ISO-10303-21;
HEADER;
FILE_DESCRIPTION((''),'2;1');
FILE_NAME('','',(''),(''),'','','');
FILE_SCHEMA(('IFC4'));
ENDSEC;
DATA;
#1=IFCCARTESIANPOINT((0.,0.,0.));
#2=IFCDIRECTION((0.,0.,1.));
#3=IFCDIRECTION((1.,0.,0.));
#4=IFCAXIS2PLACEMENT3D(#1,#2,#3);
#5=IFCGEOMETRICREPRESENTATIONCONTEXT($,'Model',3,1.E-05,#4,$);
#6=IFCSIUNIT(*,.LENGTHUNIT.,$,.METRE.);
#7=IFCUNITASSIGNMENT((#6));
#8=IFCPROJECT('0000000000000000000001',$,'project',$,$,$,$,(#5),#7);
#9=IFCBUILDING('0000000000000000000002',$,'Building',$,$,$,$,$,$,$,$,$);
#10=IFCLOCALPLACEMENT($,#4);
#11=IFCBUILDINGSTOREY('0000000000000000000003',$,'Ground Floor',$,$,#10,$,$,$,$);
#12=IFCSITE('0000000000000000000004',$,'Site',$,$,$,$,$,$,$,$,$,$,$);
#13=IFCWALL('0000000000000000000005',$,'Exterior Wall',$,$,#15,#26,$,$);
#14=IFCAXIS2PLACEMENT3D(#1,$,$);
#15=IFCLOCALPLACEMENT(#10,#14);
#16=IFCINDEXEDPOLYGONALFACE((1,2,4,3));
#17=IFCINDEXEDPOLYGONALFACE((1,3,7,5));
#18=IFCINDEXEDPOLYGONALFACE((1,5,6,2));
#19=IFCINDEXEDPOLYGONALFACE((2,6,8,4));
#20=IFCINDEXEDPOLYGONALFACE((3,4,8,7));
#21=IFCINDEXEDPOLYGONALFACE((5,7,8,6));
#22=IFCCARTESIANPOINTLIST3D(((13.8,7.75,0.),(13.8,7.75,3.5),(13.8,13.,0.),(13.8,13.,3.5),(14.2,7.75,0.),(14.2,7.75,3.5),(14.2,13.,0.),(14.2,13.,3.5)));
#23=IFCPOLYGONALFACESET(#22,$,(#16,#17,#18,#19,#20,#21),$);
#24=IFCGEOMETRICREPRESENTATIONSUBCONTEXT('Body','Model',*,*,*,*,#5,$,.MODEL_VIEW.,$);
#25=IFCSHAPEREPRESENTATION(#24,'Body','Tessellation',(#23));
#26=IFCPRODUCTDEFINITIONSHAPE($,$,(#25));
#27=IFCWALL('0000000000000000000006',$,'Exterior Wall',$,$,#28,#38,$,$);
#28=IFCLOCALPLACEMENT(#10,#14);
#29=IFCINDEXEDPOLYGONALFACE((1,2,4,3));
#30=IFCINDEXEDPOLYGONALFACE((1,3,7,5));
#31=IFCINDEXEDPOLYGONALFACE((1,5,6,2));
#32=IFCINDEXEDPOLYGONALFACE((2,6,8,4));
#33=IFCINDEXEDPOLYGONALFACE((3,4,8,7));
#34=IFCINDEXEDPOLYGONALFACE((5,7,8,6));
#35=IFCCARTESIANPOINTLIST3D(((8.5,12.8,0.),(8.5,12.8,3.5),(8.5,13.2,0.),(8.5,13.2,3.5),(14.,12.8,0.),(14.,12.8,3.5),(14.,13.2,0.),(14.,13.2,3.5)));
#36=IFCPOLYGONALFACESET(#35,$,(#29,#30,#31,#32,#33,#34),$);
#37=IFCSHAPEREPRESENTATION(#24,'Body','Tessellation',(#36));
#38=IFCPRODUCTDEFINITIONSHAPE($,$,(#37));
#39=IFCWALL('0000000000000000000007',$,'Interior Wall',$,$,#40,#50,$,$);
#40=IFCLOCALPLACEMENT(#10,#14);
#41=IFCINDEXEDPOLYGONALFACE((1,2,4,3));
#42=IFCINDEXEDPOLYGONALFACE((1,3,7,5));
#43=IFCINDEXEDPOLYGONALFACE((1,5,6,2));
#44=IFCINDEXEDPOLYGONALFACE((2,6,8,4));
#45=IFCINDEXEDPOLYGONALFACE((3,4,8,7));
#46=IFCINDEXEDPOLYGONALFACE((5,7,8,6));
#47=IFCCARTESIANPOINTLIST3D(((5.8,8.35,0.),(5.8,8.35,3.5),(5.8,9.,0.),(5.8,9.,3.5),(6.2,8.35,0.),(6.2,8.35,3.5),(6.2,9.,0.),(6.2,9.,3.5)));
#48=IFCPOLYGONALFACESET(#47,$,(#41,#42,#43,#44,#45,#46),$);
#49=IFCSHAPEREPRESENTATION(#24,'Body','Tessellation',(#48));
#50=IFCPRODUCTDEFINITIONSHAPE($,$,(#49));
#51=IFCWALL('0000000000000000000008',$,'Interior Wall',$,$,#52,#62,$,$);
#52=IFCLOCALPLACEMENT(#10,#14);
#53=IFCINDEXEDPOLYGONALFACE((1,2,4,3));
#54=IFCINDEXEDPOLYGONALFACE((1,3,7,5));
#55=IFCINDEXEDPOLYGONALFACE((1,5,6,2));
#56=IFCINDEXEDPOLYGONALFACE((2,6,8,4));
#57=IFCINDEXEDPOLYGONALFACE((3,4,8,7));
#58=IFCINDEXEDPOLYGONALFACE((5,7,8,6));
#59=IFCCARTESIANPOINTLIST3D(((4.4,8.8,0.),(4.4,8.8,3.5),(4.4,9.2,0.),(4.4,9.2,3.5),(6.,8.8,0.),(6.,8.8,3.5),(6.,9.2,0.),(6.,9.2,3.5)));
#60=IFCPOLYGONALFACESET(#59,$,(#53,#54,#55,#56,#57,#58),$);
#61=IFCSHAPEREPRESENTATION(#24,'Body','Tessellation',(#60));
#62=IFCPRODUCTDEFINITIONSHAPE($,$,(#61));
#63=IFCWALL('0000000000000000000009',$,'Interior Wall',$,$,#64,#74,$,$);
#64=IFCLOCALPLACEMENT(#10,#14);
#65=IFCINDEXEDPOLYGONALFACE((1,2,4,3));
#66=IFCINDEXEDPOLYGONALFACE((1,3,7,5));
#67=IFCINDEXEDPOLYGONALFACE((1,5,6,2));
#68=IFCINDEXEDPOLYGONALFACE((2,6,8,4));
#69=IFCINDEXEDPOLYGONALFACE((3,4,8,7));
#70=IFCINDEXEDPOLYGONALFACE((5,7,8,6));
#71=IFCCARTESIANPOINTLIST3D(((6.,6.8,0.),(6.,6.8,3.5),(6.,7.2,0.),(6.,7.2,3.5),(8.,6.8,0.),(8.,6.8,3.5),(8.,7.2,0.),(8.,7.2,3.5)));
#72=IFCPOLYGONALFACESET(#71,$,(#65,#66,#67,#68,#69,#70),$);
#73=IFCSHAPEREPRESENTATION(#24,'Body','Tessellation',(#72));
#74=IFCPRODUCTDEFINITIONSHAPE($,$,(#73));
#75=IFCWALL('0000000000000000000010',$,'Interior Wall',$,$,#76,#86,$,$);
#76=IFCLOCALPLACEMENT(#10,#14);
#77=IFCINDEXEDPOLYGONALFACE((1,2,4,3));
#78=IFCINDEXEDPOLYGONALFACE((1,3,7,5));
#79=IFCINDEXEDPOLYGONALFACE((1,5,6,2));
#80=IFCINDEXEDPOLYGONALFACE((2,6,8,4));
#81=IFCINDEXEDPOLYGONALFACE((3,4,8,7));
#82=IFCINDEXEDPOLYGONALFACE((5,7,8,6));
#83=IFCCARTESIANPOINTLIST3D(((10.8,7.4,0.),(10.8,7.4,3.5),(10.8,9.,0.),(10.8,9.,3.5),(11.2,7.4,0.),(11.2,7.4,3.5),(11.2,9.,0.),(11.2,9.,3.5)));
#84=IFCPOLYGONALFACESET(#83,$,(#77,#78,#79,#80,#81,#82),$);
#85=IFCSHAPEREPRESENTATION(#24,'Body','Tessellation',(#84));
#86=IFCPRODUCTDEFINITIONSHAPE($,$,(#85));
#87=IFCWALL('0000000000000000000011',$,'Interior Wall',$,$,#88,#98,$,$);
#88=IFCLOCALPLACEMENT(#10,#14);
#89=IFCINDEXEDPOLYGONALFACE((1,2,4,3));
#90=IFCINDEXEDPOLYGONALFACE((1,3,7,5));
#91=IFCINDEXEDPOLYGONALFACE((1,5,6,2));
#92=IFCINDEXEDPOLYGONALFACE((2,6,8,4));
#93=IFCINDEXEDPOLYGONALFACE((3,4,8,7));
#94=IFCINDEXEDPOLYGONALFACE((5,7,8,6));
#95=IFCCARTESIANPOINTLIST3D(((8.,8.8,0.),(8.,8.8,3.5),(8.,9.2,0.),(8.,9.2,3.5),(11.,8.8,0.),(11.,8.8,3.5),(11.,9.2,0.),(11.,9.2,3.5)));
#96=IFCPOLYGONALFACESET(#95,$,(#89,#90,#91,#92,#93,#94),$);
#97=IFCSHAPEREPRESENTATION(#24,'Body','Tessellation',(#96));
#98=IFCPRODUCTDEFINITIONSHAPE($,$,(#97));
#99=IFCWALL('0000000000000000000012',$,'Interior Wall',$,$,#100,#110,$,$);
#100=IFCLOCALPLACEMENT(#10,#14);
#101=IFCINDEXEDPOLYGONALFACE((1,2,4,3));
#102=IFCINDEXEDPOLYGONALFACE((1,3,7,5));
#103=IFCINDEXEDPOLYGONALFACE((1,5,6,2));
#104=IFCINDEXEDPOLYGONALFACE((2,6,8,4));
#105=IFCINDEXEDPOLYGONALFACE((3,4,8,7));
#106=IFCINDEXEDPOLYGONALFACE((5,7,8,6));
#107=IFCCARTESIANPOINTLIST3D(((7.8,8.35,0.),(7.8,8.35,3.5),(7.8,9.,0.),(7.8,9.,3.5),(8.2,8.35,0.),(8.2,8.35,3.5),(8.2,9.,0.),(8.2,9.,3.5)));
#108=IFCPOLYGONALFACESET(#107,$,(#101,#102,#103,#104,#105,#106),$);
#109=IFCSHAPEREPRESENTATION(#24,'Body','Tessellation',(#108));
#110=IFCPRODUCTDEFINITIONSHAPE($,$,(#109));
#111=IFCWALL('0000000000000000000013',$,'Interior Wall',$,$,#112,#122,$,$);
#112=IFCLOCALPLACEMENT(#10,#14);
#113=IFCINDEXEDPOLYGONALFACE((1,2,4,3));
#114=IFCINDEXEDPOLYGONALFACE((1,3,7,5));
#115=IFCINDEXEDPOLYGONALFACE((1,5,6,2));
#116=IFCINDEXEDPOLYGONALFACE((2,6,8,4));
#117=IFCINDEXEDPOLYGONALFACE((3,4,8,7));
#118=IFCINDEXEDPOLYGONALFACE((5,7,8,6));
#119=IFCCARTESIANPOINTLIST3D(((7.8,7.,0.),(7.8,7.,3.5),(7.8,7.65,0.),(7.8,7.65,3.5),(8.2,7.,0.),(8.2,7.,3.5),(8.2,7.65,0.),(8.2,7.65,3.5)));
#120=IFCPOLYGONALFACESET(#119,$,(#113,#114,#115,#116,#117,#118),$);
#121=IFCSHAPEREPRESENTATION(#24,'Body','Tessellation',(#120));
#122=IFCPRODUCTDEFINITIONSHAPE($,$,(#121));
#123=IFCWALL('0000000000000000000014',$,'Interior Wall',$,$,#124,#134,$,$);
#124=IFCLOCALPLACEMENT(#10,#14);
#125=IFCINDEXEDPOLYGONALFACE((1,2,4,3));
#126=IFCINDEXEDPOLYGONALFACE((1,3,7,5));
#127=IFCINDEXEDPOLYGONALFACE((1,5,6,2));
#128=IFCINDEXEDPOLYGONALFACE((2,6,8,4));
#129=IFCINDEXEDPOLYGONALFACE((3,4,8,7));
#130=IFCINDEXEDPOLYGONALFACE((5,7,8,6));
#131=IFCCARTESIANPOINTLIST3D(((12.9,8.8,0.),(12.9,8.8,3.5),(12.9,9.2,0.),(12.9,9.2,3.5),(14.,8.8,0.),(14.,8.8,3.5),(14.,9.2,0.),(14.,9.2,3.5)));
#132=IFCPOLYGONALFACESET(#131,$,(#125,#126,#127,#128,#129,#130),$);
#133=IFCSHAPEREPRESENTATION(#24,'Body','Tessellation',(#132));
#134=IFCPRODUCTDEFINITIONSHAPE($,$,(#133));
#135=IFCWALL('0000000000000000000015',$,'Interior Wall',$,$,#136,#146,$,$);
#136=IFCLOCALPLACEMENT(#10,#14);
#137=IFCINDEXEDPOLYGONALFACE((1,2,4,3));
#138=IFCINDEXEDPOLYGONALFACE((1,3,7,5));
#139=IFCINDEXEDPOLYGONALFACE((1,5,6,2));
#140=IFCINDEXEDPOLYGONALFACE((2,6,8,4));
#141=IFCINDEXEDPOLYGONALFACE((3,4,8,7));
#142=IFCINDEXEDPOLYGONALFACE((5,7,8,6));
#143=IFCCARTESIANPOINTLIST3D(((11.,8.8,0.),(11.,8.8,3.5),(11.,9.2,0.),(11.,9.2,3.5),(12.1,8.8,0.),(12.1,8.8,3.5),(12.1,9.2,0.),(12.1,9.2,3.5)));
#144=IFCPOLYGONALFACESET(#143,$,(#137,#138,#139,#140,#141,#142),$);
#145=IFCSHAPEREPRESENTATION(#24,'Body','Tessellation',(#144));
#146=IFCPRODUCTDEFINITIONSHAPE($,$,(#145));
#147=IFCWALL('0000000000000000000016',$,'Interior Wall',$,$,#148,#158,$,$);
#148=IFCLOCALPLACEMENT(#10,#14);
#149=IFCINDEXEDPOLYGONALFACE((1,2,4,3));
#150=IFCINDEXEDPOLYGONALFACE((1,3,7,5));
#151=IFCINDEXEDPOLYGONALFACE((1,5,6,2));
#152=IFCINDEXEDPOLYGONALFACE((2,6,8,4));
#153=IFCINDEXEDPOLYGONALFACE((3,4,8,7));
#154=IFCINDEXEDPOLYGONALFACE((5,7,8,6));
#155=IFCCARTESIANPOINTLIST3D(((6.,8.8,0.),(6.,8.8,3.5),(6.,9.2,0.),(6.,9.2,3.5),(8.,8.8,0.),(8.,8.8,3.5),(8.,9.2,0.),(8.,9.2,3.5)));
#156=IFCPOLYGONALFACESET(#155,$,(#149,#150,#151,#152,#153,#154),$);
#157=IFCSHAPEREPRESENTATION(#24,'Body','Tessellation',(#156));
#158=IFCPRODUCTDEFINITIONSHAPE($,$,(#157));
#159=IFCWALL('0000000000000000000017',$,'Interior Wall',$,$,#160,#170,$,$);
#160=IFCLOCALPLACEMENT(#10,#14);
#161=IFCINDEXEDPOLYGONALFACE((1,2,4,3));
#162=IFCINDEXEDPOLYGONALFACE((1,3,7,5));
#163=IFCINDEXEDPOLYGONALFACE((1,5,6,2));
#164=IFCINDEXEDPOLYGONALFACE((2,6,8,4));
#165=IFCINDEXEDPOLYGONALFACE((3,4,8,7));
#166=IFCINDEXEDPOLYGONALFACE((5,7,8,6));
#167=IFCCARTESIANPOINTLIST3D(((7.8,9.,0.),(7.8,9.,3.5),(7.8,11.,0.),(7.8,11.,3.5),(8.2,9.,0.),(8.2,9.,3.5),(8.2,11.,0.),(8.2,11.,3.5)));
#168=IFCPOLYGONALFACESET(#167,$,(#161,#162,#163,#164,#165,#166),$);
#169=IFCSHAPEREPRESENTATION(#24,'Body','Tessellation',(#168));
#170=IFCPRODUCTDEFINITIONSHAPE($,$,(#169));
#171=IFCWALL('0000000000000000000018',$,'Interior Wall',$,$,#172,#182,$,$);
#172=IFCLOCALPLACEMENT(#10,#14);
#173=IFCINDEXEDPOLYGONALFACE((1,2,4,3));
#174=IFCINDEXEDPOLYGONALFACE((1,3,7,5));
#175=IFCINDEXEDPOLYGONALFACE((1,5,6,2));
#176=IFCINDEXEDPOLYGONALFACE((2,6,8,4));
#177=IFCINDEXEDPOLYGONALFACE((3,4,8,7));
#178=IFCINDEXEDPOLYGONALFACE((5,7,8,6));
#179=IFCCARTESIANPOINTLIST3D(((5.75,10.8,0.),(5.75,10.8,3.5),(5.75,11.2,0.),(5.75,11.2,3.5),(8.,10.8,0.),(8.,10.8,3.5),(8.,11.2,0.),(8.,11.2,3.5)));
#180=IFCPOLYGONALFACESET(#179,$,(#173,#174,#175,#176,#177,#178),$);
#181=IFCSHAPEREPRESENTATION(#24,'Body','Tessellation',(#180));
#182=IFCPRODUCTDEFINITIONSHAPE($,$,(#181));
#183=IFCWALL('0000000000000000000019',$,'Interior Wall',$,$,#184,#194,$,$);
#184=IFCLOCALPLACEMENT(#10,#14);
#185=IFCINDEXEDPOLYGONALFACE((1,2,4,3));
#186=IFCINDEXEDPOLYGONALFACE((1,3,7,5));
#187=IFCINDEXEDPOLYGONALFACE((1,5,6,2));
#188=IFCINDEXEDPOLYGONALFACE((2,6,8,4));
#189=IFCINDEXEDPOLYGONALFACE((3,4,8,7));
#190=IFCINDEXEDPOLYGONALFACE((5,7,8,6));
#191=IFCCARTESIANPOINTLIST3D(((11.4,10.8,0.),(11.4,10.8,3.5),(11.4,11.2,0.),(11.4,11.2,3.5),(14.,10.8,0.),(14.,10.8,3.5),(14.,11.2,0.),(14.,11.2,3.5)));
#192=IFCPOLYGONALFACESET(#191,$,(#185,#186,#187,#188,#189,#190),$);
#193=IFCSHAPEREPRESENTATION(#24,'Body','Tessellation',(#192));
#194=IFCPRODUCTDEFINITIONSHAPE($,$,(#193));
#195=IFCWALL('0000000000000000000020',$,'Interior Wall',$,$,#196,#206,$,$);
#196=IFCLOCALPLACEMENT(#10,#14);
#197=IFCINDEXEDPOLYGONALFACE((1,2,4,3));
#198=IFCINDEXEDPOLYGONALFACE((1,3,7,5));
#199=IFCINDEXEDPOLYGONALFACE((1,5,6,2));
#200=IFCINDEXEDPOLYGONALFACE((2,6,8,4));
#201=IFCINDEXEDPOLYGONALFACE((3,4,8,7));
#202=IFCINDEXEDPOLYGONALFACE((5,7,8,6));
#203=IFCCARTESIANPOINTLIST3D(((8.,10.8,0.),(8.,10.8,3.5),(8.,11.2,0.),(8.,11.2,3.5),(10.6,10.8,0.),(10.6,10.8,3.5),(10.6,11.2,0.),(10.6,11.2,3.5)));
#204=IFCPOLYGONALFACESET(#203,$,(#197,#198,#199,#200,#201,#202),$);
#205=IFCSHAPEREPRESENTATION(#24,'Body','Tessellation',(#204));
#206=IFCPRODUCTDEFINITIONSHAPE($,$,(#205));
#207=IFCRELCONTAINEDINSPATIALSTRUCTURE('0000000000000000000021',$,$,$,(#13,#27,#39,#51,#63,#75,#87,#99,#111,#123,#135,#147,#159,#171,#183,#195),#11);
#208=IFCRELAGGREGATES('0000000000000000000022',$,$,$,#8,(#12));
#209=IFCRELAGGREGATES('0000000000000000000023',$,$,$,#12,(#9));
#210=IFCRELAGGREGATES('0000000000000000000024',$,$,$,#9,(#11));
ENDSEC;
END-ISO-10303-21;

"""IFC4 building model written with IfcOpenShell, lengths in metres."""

from ifc_helpers import new_model, si_unit, frame, origin_with_axes, place, context, subcontext, project, spatial, indexed_curve, outline, extrude, element, save


model = new_model("IFC4")

# Units and contexts
model_context = context("Model", 3, precision=1e-05, world=origin_with_axes())
body_context = subcontext(model_context, "Body", "Model", "MODEL_VIEW")
ifc_project = project(units=[si_unit("LENGTHUNIT", "METRE")], contexts=[model_context])

# Site, building, storey
site = spatial("IfcSite", under=ifc_project, Name="Site")
building = spatial("IfcBuilding", under=site, Name="Building")
storey_placement = place(None, origin_with_axes())
storey = spatial("IfcBuildingStorey", under=building, at=storey_placement, Name="Ground Floor")

# Walls
wall_1_placement = place(storey_placement, frame((14.0, 7.75, 0.0), z_axis=(0.0, 0.0, 1.0), x_axis=(0.0, 1.0, 0.0)))
element("IfcWall", 1, at=wall_1_placement, inside=storey, Name="Exterior Wall", context=body_context, shape_type="SweptSolid", body=[
    extrude(outline(indexed_curve([(0.0, 0.0), (0.0, 0.4), (5.25, 0.4), (5.25, 0.0), (0.0, 0.0)], self_intersect=False)), frame((0.0, -0.2, 0.0), z_axis=(0.0, 0.0, 1.0), x_axis=(1.0, 0.0, 0.0)), (0.0, 0.0, 1.0), 3.5),
])
wall_2_placement = place(storey_placement, frame((14.0, 13.0, 0.0), z_axis=(0.0, 0.0, 1.0), x_axis=(-1.0, 0.0, 0.0)))
element("IfcWall", 2, at=wall_2_placement, inside=storey, Name="Exterior Wall", context=body_context, shape_type="SweptSolid", body=[
    extrude(outline(indexed_curve([(0.0, 0.0), (0.0, 0.4), (5.5, 0.4), (5.5, 0.0), (0.0, 0.0)], self_intersect=False)), frame((0.0, -0.2, 0.0), z_axis=(0.0, 0.0, 1.0), x_axis=(1.0, 0.0, 0.0)), (0.0, 0.0, 1.0), 3.5),
])
wall_3_placement = place(storey_placement, frame((6.0, 8.35, 0.0), z_axis=(0.0, 0.0, 1.0), x_axis=(0.0, 1.0, 0.0)))
element("IfcWall", 3, at=wall_3_placement, inside=storey, Name="Interior Wall", context=body_context, shape_type="SweptSolid", body=[
    extrude(outline(indexed_curve([(0.0, 0.0), (0.0, 0.4), (0.65, 0.4), (0.65, 0.0), (0.0, 0.0)], self_intersect=False)), frame((0.0, -0.2, 0.0), z_axis=(0.0, 0.0, 1.0), x_axis=(1.0, 0.0, 0.0)), (0.0, 0.0, 1.0), 3.5),
])
wall_4_placement = place(storey_placement, frame((6.0, 9.0, 0.0), z_axis=(0.0, 0.0, 1.0), x_axis=(-1.0, 0.0, 0.0)))
element("IfcWall", 4, at=wall_4_placement, inside=storey, Name="Interior Wall", context=body_context, shape_type="SweptSolid", body=[
    extrude(outline(indexed_curve([(0.0, 0.0), (0.0, 0.4), (1.6, 0.4), (1.6, 0.0), (0.0, 0.0)], self_intersect=False)), frame((0.0, -0.2, 0.0), z_axis=(0.0, 0.0, 1.0), x_axis=(1.0, 0.0, 0.0)), (0.0, 0.0, 1.0), 3.5),
])
wall_5_placement = place(storey_placement, frame((8.0, 7.0, 0.0), z_axis=(0.0, 0.0, 1.0), x_axis=(-1.0, 0.0, 0.0)))
element("IfcWall", 5, at=wall_5_placement, inside=storey, Name="Interior Wall", context=body_context, shape_type="SweptSolid", body=[
    extrude(outline(indexed_curve([(0.0, 0.0), (0.0, 0.4), (2.0, 0.4), (2.0, 0.0), (0.0, 0.0)], self_intersect=False)), frame((0.0, -0.2, 0.0), z_axis=(0.0, 0.0, 1.0), x_axis=(1.0, 0.0, 0.0)), (0.0, 0.0, 1.0), 3.5),
])
wall_6_placement = place(storey_placement, frame((11.0, 7.4, 0.0), z_axis=(0.0, 0.0, 1.0), x_axis=(0.0, 1.0, 0.0)))
element("IfcWall", 6, at=wall_6_placement, inside=storey, Name="Interior Wall", context=body_context, shape_type="SweptSolid", body=[
    extrude(outline(indexed_curve([(0.0, 0.0), (0.0, 0.4), (1.6, 0.4), (1.6, 0.0), (0.0, 0.0)], self_intersect=False)), frame((0.0, -0.2, 0.0), z_axis=(0.0, 0.0, 1.0), x_axis=(1.0, 0.0, 0.0)), (0.0, 0.0, 1.0), 3.5),
])
wall_7_placement = place(storey_placement, frame((11.0, 9.0, 0.0), z_axis=(0.0, 0.0, 1.0), x_axis=(-1.0, 0.0, 0.0)))
element("IfcWall", 7, at=wall_7_placement, inside=storey, Name="Interior Wall", context=body_context, shape_type="SweptSolid", body=[
    extrude(outline(indexed_curve([(0.0, 0.0), (0.0, 0.4), (3.0, 0.4), (3.0, 0.0), (0.0, 0.0)], self_intersect=False)), frame((0.0, -0.2, 0.0), z_axis=(0.0, 0.0, 1.0), x_axis=(1.0, 0.0, 0.0)), (0.0, 0.0, 1.0), 3.5),
])
for number, where, z_axis, x_axis, name in (
    (8, (8.0, 9.0, 0.0), (0.0, 0.0, 1.0), (0.0, -1.0, 0.0), "Interior Wall"),
    (9, (8.0, 7.65, 0.0), (0.0, 0.0, 1.0), (0.0, -1.0, 0.0), "Interior Wall"),
):
    element("IfcWall", number, at=place(storey_placement, frame(where, z_axis=z_axis, x_axis=x_axis)), inside=storey, Name=name, context=body_context, shape_type="SweptSolid", body=[
        extrude(outline(indexed_curve([(0.0, 0.0), (0.0, 0.4), (0.65, 0.4), (0.65, 0.0), (0.0, 0.0)], self_intersect=False)), frame((0.0, -0.2, 0.0), z_axis=(0.0, 0.0, 1.0), x_axis=(1.0, 0.0, 0.0)), (0.0, 0.0, 1.0), 3.5),
    ])
for number, where, z_axis, x_axis, name in (
    (10, (14.0, 9.0, 0.0), (0.0, 0.0, 1.0), (-1.0, 0.0, 0.0), "Interior Wall"),
    (11, (12.1, 9.0, 0.0), (0.0, 0.0, 1.0), (-1.0, 0.0, 0.0), "Interior Wall"),
):
    element("IfcWall", number, at=place(storey_placement, frame(where, z_axis=z_axis, x_axis=x_axis)), inside=storey, Name=name, context=body_context, shape_type="SweptSolid", body=[
        extrude(outline(indexed_curve([(0.0, 0.0), (0.0, 0.4), (1.1, 0.4), (1.1, 0.0), (0.0, 0.0)], self_intersect=False)), frame((0.0, -0.2, 0.0), z_axis=(0.0, 0.0, 1.0), x_axis=(1.0, 0.0, 0.0)), (0.0, 0.0, 1.0), 3.5),
    ])
for number, where, z_axis, x_axis, name in (
    (12, (8.0, 9.0, 0.0), (0.0, 0.0, 1.0), (-1.0, 0.0, 0.0), "Interior Wall"),
    (13, (8.0, 9.0, 0.0), (0.0, 0.0, 1.0), (0.0, 1.0, 0.0), "Interior Wall"),
):
    element("IfcWall", number, at=place(storey_placement, frame(where, z_axis=z_axis, x_axis=x_axis)), inside=storey, Name=name, context=body_context, shape_type="SweptSolid", body=[
        extrude(outline(indexed_curve([(0.0, 0.0), (0.0, 0.4), (2.0, 0.4), (2.0, 0.0), (0.0, 0.0)], self_intersect=False)), frame((0.0, -0.2, 0.0), z_axis=(0.0, 0.0, 1.0), x_axis=(1.0, 0.0, 0.0)), (0.0, 0.0, 1.0), 3.5),
    ])
wall_8_placement = place(storey_placement, frame((8.0, 11.0, 0.0), z_axis=(0.0, 0.0, 1.0), x_axis=(-1.0, 0.0, 0.0)))
element("IfcWall", 14, at=wall_8_placement, inside=storey, Name="Interior Wall", context=body_context, shape_type="SweptSolid", body=[
    extrude(outline(indexed_curve([(0.0, 0.0), (0.0, 0.4), (2.25, 0.4), (2.25, 0.0), (0.0, 0.0)], self_intersect=False)), frame((0.0, -0.2, 0.0), z_axis=(0.0, 0.0, 1.0), x_axis=(1.0, 0.0, 0.0)), (0.0, 0.0, 1.0), 3.5),
])
for number, where, z_axis, x_axis, name in (
    (15, (14.0, 11.0, 0.0), (0.0, 0.0, 1.0), (-1.0, 0.0, 0.0), "Interior Wall"),
    (16, (10.6, 11.0, 0.0), (0.0, 0.0, 1.0), (-1.0, 0.0, 0.0), "Interior Wall"),
):
    element("IfcWall", number, at=place(storey_placement, frame(where, z_axis=z_axis, x_axis=x_axis)), inside=storey, Name=name, context=body_context, shape_type="SweptSolid", body=[
        extrude(outline(indexed_curve([(0.0, 0.0), (0.0, 0.4), (2.6, 0.4), (2.6, 0.0), (0.0, 0.0)], self_intersect=False)), frame((0.0, -0.2, 0.0), z_axis=(0.0, 0.0, 1.0), x_axis=(1.0, 0.0, 0.0)), (0.0, 0.0, 1.0), 3.5),
    ])

save(model, "model.ifc")
